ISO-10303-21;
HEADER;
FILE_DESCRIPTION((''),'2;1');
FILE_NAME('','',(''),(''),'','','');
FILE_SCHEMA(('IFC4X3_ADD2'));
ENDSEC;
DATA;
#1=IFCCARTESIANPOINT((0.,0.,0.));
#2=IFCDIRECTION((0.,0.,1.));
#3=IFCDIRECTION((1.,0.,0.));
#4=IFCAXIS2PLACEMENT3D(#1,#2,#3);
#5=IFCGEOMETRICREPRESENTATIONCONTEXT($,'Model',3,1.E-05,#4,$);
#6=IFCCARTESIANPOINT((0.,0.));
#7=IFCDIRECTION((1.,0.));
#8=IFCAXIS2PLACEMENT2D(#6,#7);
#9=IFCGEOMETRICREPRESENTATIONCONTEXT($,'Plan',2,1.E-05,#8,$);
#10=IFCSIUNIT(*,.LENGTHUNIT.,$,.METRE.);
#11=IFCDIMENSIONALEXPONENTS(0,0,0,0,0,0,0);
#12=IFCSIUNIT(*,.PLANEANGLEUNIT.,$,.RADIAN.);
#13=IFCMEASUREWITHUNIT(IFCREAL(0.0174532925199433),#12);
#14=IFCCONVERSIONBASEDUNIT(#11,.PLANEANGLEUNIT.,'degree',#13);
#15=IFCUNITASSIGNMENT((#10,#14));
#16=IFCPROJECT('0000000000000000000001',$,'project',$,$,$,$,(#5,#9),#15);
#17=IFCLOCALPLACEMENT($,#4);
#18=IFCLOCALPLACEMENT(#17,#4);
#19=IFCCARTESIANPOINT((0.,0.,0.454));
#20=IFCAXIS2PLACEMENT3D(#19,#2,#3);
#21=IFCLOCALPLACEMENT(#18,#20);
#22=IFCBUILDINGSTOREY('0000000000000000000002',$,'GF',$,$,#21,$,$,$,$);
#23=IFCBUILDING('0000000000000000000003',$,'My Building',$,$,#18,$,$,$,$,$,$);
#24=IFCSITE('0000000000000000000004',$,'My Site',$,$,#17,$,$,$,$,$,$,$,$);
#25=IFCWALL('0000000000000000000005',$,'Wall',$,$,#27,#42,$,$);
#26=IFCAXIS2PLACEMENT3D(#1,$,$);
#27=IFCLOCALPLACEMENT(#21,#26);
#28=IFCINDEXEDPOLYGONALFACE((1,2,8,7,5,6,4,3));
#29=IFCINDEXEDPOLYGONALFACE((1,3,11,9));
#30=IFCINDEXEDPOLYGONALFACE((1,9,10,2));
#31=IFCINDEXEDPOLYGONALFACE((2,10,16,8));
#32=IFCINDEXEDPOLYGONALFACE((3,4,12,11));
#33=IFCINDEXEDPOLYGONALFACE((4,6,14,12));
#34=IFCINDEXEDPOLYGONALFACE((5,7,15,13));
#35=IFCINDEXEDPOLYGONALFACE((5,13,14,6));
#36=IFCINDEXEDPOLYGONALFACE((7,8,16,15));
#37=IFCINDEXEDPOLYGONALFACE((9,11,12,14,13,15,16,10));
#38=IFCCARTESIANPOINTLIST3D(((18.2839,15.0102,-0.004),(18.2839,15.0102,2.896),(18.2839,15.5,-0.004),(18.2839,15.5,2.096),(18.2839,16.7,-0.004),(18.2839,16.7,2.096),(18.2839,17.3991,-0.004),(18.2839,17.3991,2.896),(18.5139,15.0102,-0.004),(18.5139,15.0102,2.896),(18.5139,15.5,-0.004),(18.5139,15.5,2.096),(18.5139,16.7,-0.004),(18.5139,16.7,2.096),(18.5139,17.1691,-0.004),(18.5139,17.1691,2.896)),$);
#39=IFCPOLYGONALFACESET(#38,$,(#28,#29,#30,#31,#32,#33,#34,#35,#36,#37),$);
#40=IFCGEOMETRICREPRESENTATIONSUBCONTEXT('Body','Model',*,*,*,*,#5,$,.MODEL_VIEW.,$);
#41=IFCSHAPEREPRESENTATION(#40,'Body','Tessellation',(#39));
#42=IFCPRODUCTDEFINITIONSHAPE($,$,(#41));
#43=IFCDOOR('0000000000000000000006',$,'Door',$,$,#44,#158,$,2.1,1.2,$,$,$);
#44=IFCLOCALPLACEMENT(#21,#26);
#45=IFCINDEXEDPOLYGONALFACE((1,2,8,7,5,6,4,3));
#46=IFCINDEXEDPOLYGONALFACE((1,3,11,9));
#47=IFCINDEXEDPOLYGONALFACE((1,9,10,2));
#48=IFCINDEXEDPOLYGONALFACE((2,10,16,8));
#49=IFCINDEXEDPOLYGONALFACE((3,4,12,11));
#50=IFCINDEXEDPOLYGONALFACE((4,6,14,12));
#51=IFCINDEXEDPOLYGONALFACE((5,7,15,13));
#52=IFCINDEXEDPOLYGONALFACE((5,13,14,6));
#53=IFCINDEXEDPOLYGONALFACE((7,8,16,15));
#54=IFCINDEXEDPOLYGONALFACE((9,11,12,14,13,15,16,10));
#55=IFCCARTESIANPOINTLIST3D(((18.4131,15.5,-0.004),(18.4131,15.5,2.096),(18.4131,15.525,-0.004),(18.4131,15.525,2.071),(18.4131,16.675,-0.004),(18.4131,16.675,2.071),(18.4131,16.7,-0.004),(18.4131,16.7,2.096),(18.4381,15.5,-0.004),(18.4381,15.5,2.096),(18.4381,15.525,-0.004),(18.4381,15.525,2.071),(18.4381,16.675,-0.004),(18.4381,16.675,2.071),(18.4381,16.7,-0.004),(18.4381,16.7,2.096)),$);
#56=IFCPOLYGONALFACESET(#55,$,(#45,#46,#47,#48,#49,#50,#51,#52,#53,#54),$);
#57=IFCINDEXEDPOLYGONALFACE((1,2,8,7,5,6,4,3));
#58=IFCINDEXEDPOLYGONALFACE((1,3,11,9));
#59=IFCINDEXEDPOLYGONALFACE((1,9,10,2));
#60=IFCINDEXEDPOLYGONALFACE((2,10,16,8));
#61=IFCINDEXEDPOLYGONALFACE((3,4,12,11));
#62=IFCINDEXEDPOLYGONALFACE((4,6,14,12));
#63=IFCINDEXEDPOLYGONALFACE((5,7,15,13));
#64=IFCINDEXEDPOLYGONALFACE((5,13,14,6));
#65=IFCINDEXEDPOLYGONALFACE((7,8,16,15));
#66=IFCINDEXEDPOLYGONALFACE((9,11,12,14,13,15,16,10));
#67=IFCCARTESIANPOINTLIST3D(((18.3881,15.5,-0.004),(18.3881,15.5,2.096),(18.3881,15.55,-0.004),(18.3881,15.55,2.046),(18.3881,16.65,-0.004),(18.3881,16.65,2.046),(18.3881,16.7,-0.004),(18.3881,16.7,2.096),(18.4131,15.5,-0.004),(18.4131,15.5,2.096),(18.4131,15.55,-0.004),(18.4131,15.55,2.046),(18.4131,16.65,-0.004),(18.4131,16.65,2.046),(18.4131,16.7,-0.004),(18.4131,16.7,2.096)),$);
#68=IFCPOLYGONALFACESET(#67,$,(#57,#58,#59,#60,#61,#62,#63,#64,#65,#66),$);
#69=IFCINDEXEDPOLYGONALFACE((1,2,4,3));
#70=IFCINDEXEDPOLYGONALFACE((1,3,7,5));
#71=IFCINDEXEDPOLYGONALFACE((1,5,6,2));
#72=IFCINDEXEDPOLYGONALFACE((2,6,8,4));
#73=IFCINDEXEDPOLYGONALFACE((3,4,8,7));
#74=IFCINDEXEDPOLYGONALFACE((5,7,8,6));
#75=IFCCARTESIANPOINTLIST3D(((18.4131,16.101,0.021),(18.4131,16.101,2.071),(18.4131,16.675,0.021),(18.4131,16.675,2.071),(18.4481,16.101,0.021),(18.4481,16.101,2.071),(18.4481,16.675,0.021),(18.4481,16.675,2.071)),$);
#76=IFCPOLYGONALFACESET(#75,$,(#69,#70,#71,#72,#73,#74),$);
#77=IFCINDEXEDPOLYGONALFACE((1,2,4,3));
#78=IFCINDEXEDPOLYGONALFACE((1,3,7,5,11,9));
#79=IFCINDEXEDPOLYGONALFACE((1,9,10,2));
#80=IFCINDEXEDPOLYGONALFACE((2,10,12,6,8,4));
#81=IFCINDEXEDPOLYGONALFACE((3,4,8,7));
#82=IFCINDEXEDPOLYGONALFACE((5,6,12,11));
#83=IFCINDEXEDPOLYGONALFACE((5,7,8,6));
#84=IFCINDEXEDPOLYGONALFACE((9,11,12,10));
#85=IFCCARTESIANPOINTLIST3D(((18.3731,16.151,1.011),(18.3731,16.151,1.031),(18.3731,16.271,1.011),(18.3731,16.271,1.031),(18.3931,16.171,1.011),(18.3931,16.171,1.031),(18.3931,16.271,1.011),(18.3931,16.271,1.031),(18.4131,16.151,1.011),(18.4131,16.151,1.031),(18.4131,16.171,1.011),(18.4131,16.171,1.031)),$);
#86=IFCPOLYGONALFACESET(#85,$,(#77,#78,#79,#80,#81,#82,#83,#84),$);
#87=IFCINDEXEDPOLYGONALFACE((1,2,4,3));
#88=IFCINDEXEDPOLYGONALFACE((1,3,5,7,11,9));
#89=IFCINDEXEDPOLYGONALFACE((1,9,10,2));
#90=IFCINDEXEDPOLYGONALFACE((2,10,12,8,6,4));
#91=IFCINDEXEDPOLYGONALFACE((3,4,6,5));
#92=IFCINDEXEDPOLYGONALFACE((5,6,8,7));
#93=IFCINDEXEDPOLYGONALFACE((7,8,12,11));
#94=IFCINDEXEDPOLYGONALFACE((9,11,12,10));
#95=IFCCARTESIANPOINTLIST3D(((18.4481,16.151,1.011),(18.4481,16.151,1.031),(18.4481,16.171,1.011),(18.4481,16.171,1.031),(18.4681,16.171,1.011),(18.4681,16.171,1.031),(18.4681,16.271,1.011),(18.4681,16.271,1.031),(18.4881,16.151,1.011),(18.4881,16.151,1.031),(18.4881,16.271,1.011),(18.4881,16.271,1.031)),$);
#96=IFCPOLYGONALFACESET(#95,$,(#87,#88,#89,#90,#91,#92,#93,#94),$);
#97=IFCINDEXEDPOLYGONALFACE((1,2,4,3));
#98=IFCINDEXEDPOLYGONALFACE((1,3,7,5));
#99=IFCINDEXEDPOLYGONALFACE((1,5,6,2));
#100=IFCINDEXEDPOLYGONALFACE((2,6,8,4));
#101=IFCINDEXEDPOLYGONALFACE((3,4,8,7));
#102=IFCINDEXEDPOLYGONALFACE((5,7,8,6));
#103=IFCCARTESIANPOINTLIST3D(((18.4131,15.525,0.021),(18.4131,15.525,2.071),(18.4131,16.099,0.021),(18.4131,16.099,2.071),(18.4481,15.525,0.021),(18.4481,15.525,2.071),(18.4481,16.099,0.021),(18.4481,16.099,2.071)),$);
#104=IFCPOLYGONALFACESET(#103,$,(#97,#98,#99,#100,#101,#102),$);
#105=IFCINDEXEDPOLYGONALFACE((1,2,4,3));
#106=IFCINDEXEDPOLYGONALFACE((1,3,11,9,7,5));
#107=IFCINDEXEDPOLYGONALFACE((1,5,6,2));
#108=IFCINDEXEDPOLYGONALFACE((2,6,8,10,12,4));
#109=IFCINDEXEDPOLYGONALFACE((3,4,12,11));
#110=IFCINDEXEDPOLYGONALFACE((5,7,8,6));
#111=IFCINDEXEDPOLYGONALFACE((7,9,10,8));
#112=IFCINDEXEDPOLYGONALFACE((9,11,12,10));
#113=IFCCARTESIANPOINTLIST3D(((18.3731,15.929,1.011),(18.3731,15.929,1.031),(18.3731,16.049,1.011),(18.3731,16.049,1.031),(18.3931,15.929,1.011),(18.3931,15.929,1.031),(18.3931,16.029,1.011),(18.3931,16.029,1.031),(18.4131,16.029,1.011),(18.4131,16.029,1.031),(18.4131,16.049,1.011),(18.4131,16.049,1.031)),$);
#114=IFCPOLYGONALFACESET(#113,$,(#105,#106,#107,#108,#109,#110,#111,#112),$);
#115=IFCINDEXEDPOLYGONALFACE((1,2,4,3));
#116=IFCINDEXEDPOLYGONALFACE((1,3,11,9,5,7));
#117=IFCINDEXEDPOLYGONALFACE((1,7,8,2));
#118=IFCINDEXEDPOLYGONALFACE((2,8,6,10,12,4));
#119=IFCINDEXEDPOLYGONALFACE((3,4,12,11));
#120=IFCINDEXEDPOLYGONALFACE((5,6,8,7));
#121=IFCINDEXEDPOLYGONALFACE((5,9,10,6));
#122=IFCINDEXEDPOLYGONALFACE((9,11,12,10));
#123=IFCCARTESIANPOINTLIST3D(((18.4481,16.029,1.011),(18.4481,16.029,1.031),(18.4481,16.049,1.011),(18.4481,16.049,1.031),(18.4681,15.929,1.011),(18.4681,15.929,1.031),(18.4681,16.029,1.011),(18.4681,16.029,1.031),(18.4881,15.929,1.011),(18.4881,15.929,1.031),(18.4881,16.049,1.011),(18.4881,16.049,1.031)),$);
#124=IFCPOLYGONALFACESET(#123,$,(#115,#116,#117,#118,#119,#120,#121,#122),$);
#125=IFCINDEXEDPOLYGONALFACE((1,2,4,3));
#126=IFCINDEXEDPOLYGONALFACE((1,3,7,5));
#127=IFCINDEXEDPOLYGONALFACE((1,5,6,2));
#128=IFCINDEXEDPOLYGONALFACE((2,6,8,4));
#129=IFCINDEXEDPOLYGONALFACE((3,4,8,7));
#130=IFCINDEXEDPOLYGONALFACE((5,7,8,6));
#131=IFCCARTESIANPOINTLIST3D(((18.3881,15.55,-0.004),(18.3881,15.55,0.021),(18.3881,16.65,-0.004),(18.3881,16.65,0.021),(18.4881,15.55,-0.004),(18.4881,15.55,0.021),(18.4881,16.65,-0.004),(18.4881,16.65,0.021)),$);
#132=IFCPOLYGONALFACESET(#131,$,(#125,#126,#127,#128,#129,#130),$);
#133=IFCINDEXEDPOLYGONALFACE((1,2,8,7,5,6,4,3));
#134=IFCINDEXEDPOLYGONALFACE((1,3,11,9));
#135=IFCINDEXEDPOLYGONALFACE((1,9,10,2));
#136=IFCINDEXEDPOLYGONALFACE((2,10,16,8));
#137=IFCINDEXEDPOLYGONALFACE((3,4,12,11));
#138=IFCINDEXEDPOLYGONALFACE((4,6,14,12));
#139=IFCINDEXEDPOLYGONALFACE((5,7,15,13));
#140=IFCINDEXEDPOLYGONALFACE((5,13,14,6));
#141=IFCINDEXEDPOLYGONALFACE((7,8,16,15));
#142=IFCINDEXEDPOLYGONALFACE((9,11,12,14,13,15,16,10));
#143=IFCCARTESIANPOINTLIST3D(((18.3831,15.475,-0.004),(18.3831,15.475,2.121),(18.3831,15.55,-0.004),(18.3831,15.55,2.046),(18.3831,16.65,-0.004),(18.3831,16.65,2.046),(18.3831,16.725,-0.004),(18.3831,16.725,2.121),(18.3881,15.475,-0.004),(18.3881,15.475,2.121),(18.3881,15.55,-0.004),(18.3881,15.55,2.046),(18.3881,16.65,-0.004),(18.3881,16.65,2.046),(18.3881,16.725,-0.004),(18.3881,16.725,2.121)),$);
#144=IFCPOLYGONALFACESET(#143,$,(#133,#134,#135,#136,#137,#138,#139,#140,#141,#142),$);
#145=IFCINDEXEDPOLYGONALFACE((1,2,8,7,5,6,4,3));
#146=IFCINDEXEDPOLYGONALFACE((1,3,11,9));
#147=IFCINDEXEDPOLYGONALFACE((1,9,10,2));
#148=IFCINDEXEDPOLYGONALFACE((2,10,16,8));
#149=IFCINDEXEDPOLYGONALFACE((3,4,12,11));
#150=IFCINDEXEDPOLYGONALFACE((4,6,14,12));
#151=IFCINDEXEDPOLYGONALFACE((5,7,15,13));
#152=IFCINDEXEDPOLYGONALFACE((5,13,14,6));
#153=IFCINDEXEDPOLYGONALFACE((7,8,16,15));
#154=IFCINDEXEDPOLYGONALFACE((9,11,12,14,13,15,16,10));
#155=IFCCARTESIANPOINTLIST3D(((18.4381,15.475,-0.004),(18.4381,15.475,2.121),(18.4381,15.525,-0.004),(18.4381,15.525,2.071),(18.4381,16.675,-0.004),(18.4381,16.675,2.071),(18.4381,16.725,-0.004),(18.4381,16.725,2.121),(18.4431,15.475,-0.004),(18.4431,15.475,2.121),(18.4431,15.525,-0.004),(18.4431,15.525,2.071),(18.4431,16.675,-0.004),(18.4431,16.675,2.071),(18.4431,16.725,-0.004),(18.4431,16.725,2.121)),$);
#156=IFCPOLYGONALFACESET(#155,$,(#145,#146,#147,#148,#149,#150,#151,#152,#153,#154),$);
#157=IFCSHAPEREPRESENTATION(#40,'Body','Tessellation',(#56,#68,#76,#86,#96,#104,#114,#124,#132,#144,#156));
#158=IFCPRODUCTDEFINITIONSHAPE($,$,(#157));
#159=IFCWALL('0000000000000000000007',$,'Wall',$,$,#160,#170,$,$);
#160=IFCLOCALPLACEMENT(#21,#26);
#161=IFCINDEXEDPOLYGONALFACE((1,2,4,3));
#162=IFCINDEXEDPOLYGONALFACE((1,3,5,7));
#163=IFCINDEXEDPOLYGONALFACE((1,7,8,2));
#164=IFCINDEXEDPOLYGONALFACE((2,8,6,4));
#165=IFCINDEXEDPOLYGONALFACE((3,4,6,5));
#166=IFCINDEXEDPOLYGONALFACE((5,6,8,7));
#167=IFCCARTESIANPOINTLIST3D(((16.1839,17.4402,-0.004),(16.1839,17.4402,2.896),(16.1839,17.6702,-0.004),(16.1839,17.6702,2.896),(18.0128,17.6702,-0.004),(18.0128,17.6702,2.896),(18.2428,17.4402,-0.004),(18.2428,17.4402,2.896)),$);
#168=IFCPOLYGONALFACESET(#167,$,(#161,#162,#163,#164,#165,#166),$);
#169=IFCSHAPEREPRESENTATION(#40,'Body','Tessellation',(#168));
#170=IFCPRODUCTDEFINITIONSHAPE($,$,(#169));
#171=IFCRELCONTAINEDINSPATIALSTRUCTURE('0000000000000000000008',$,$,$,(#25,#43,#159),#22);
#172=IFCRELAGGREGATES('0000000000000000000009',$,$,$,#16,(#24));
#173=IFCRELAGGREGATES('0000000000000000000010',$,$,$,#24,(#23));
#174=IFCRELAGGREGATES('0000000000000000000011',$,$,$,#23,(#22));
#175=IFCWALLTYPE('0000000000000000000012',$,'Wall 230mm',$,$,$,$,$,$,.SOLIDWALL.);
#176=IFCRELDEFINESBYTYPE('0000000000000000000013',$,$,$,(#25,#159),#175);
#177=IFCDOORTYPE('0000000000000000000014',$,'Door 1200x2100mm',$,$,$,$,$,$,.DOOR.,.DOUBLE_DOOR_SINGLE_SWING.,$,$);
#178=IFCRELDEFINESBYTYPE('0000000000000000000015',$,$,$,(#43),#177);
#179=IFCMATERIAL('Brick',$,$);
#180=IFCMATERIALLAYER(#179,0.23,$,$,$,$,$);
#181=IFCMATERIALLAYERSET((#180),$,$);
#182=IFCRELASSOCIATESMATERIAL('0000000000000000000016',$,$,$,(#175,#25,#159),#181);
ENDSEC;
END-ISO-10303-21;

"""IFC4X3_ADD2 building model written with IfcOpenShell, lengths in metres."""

from ifc_helpers import new_model, entity, si_unit, converted_unit, frame, origin_with_axes, origin_2d_with_axis, place, context, subcontext, project, spatial, line, indexed_curve, outline, extrude, clip, halfspace, shape, source, transform, mapped, material, layer, layer_set, layer_usage, type_object, type_shapes, element, fill, save


model = new_model("IFC4X3_ADD2")

# Units and contexts
model_context = context("Model", 3, precision=1e-05, world=origin_with_axes())
plan_context = context("Plan", 2, precision=1e-05, world=origin_2d_with_axis())
body_context_1 = subcontext(model_context, "Body", "Model", "MODEL_VIEW")
body_context_2 = subcontext(plan_context, "Body", "Plan", "PLAN_VIEW")
ifc_project = project(units=[si_unit("LENGTHUNIT", "METRE"), converted_unit("PLANEANGLEUNIT", "degree", entity("IfcReal", 0.0174532925199433), si_unit("PLANEANGLEUNIT", "RADIAN"), dimensions=[0, 0, 0, 0, 0, 0, 0])], contexts=[model_context, plan_context])

# Site, building, storey
site_placement = place(None, origin_with_axes())
site = spatial("IfcSite", under=ifc_project, at=site_placement, Name="My Site")
building_placement = place(site_placement, origin_with_axes())
building = spatial("IfcBuilding", under=site, at=building_placement, Name="My Building")
storey_placement = place(building_placement, frame((0.0, 0.0, 0.454), z_axis=(0.0, 0.0, 1.0), x_axis=(1.0, 0.0, 0.0)))
storey = spatial("IfcBuildingStorey", under=building, at=storey_placement, Name="GF")

# Shared definitions
ifc_material_1 = material(Name="Brick")
ifc_layer_1 = layer(ifc_material_1, 0.23)
ifc_layer_set_1 = layer_set([ifc_layer_1])
wall_type = type_object("IfcWallType", Name="Wall 230mm", PredefinedType="SOLIDWALL", material=ifc_layer_set_1)

# Wall, opening, door
ifc_layer_usage_1 = layer_usage(ifc_layer_set_1, "AXIS2", "POSITIVE", 0.0)
wall_1_placement = place(storey_placement, frame((18.5139, 15.0102, -0.004), z_axis=(0.0, 0.0, 1.0), x_axis=(0.000001, 1.0, 0.0)))
wall_1 = element("IfcWall", 1, at=wall_1_placement, inside=storey, type_object=wall_type, material=ifc_layer_usage_1, Name="Wall", context=body_context_1, shape_type="Clipping", body=[
    clip(extrude(outline(indexed_curve([(0.0, 0.0), (0.0, 0.23), (2.3889, 0.23), (2.3889, 0.0), (0.0, 0.0)], self_intersect=False)), origin_with_axes(), (0.0, 0.0, 1.0), 2.9), halfspace(frame((2.1589, 0.0, -0.45), z_axis=(0.666999, -0.666998, 0.0), x_axis=(-0.707106, -0.707107, 0.0)), False)),
])
shared_shape_1 = source(origin_with_axes(), body_context_1, "Body", "SweptSolid", [
    extrude(outline(indexed_curve([(0.0, 0.0), (1.2, 0.0), (1.2, 2.1), (0.0, 2.1)], segments=[line(1, 2, 3, 4, 1)])), frame((0.0, -0.6, 0.0), z_axis=(0.0, -1.0, 0.0), x_axis=(1.0, 0.0, 0.0)), (0.0, 0.0, -1.0), 1.2),
])
opening_1_placement = place(wall_1_placement, frame((0.4898, 0.0, 0.0), z_axis=(0.0, 0.0, 1.0), x_axis=(1.0, 0.0, 0.0)))
opening_1 = element("IfcOpeningElement", 2, at=opening_1_placement, cuts=wall_1, PredefinedType="OPENING", context=body_context_1, shape_type="MappedRepresentation", body=[
    mapped(shared_shape_1, transform((0.0, 0.0, 0.0), x_axis=(1.0, 0.0, 0.0), y_axis=(0.0, 1.0, 0.0), z_axis=(0.0, 0.0, 1.0), scale=1.0)),
])
door_type_1 = type_object("IfcDoorType", Name="Door 1200x2100mm", OperationType="DOUBLE_DOOR_SINGLE_SWING", PredefinedType="DOOR")
shared_shape_2 = source(origin_with_axes(), body_context_1, "Body", "SweptSolid", [
    extrude(outline(indexed_curve([(0.0, 0.0), (0.0, 2.1), (1.2, 2.1), (1.2, 0.0), (1.175, 0.0), (1.175, 2.075), (0.025, 2.075), (0.025, 0.0)], segments=[line(1, 2, 3, 4, 5, 6, 7, 8, 1)])), frame((0.0, 0.025, 0.0), z_axis=(0.0, -1.0, 0.0), x_axis=(1.0, 0.0, 0.0)), (0.0, 0.0, -1.0), 0.025),
    extrude(outline(indexed_curve([(0.0, 0.0), (0.0, 2.1), (1.2, 2.1), (1.2, 0.0), (1.15, 0.0), (1.15, 2.05), (0.05, 2.05), (0.05, 0.0)], segments=[line(1, 2, 3, 4, 5, 6, 7, 8, 1)])), frame((0.0, 0.0, 0.0), z_axis=(0.0, -1.0, 0.0), x_axis=(1.0, 0.0, 0.0)), (0.0, 0.0, -1.0), 0.025),
    extrude(outline(indexed_curve([(0.0, 0.0), (0.574, 0.0), (0.574, 0.035), (0.0, 0.035)], segments=[line(1, 2, 3, 4, 1)])), frame((0.025, 0.025, 0.025), z_axis=(0.0, 0.0, 1.0), x_axis=(1.0, 0.0, 0.0)), (0.0, 0.0, 1.0), 2.05),
    extrude(outline(indexed_curve([(0.0, 0.0), (0.0, -0.04), (-0.12, -0.04), (-0.12, -0.02), (-0.02, -0.02), (-0.02, 0.0)], segments=[line(1, 2, 3, 4, 5, 6, 1)])), frame((0.549, 0.025, 1.015), z_axis=(0.0, 0.0, 1.0), x_axis=(1.0, 0.0, 0.0)), (0.0, 0.0, 1.0), 0.02),
    extrude(outline(indexed_curve([(0.0, 0.0), (0.0, 0.04), (-0.12, 0.04), (-0.12, 0.02), (-0.02, 0.02), (-0.02, 0.0)], segments=[line(1, 2, 3, 4, 5, 6, 1)])), frame((0.549, 0.06, 1.015), z_axis=(0.0, 0.0, 1.0), x_axis=(1.0, 0.0, 0.0)), (0.0, 0.0, 1.0), 0.02),
    extrude(outline(indexed_curve([(0.0, 0.0), (-0.574, 0.0), (-0.574, 0.035), (0.0, 0.035)], segments=[line(1, 2, 3, 4, 1)])), frame((1.175, 0.025, 0.025), z_axis=(0.0, 0.0, 1.0), x_axis=(1.0, 0.0, 0.0)), (0.0, 0.0, 1.0), 2.05),
    extrude(outline(indexed_curve([(0.0, 0.0), (0.0, -0.04), (0.12, -0.04), (0.12, -0.02), (0.02, -0.02), (0.02, 0.0)], segments=[line(1, 2, 3, 4, 5, 6, 1)])), frame((0.651, 0.025, 1.015), z_axis=(0.0, 0.0, 1.0), x_axis=(1.0, 0.0, 0.0)), (0.0, 0.0, 1.0), 0.02),
    extrude(outline(indexed_curve([(0.0, 0.0), (0.0, 0.04), (0.12, 0.04), (0.12, 0.02), (0.02, 0.02), (0.02, 0.0)], segments=[line(1, 2, 3, 4, 5, 6, 1)])), frame((0.651, 0.06, 1.015), z_axis=(0.0, 0.0, 1.0), x_axis=(1.0, 0.0, 0.0)), (0.0, 0.0, 1.0), 0.02),
    extrude(outline(indexed_curve([(0.0, 0.0), (1.1, 0.0), (1.1, 0.1), (0.0, 0.1)], segments=[line(1, 2, 3, 4, 1)])), frame((0.05, 0.0, 0.0), z_axis=(0.0, 0.0, 1.0), x_axis=(1.0, 0.0, 0.0)), (0.0, 0.0, 1.0), 0.025),
    extrude(outline(indexed_curve([(0.0, 0.0), (0.0, 2.125), (1.25, 2.125), (1.25, 0.0), (1.175, 0.0), (1.175, 2.05), (0.075, 2.05), (0.075, 0.0)], segments=[line(1, 2, 3, 4, 5, 6, 7, 8, 1)])), frame((-0.025, -0.005, 0.0), z_axis=(0.0, -1.0, 0.0), x_axis=(1.0, 0.0, 0.0)), (0.0, 0.0, -1.0), 0.005),
    extrude(outline(indexed_curve([(0.0, 0.0), (0.0, 2.125), (1.25, 2.125), (1.25, 0.0), (1.2, 0.0), (1.2, 2.075), (0.05, 2.075), (0.05, 0.0)], segments=[line(1, 2, 3, 4, 5, 6, 7, 8, 1)])), frame((-0.025, 0.05, 0.0), z_axis=(0.0, -1.0, 0.0), x_axis=(1.0, 0.0, 0.0)), (0.0, 0.0, -1.0), 0.005),
])
shared_shape_3 = source(origin_with_axes(), body_context_2, "Body", "Curve2D", [
    entity("IfcIndexedPolyCurve", entity("IfcCartesianPointList2D", [[0.0, 0.0], [0.0, 0.05], [0.025, 0.05], [0.025, 0.025], [0.05, 0.025], [0.05, 0.0]]), [entity("IfcLineIndex", [1, 2, 3, 4, 5, 6, 1])]),
    entity("IfcIndexedPolyCurve", entity("IfcCartesianPointList2D", [[1.2, 0.0], [1.2, 0.05], [1.175, 0.05], [1.175, 0.025], [1.15, 0.025], [1.15, 0.0]]), [entity("IfcLineIndex", [1, 2, 3, 4, 5, 6, 1])]),
    entity("IfcTrimmedCurve", entity("IfcEllipse", entity("IfcAxis2Placement2D", entity("IfcCartesianPoint", [0.06, 0.05]), entity("IfcDirection", [1.0, 0.0])), 0.54, 0.575), [entity("IfcCartesianPoint", [0.6, 0.05])], [entity("IfcCartesianPoint", [0.06, 0.625])], True, "CARTESIAN"),
    entity("IfcIndexedPolyCurve", entity("IfcCartesianPointList2D", [[0.025, 0.05], [0.06, 0.05], [0.06, 0.625], [0.025, 0.625]]), [entity("IfcLineIndex", [1, 2, 3, 4, 1])]),
    entity("IfcTrimmedCurve", entity("IfcEllipse", entity("IfcAxis2Placement2D", entity("IfcCartesianPoint", [1.14, 0.05]), entity("IfcDirection", [1.0, 0.0])), 0.54, 0.575), [entity("IfcCartesianPoint", [1.14, 0.625])], [entity("IfcCartesianPoint", [0.6, 0.05])], True, "CARTESIAN"),
    entity("IfcIndexedPolyCurve", entity("IfcCartesianPointList2D", [[1.175, 0.05], [1.14, 0.05], [1.14, 0.625], [1.175, 0.625]]), [entity("IfcLineIndex", [1, 2, 3, 4, 1])]),
])
type_shapes(door_type_1, [shared_shape_2, shared_shape_3])
door_1_placement = place(opening_1_placement, frame((1.2, 0.1258, 0.0), z_axis=(0.0, 0.0, 1.0), x_axis=(-1.0, 0.0, 0.0)))
door_1 = element("IfcDoor", 3, at=door_1_placement, inside=storey, type_object=door_type_1, Name="Door", OverallHeight=2.1, OverallWidth=1.2, shapes=[
    shape(body_context_1, "Body", "MappedRepresentation", [mapped(shared_shape_2, transform((0.0, 0.0, 0.0), x_axis=(1.0, 0.0, 0.0), y_axis=(0.0, 1.0, 0.0), z_axis=(0.0, 0.0, 1.0), scale=1.0))]),
    shape(body_context_2, "Body", "MappedRepresentation", [mapped(shared_shape_3, transform((0.0, 0.0, 0.0), x_axis=(1.0, 0.0, 0.0), y_axis=(0.0, 1.0, 0.0), z_axis=(0.0, 0.0, 1.0), scale=1.0))]),
])
fill(opening_1, door_1)

# Wall
ifc_layer_usage_2 = layer_usage(ifc_layer_set_1, "AXIS2", "POSITIVE", 0.0)
wall_2_placement = place(storey_placement, frame((18.2428, 17.6702, -0.004), z_axis=(0.0, 0.0, 1.0), x_axis=(-1.0, 0.0, 0.0)))
element("IfcWall", 4, at=wall_2_placement, inside=storey, type_object=wall_type, material=ifc_layer_usage_2, Name="Wall", context=body_context_1, shape_type="Clipping", body=[
    clip(extrude(outline(indexed_curve([(0.0, 0.0), (0.0, 0.23), (2.0589, 0.23), (2.0589, 0.0), (0.0, 0.0)], self_intersect=False)), origin_with_axes(), (0.0, 0.0, 1.0), 2.9), halfspace(frame((0.23, 0.0, -0.454), z_axis=(-0.689999, -0.689999, 0.0), x_axis=(-0.707107, 0.707107, 0.0)), False)),
])

save(model, "model.ifc")
